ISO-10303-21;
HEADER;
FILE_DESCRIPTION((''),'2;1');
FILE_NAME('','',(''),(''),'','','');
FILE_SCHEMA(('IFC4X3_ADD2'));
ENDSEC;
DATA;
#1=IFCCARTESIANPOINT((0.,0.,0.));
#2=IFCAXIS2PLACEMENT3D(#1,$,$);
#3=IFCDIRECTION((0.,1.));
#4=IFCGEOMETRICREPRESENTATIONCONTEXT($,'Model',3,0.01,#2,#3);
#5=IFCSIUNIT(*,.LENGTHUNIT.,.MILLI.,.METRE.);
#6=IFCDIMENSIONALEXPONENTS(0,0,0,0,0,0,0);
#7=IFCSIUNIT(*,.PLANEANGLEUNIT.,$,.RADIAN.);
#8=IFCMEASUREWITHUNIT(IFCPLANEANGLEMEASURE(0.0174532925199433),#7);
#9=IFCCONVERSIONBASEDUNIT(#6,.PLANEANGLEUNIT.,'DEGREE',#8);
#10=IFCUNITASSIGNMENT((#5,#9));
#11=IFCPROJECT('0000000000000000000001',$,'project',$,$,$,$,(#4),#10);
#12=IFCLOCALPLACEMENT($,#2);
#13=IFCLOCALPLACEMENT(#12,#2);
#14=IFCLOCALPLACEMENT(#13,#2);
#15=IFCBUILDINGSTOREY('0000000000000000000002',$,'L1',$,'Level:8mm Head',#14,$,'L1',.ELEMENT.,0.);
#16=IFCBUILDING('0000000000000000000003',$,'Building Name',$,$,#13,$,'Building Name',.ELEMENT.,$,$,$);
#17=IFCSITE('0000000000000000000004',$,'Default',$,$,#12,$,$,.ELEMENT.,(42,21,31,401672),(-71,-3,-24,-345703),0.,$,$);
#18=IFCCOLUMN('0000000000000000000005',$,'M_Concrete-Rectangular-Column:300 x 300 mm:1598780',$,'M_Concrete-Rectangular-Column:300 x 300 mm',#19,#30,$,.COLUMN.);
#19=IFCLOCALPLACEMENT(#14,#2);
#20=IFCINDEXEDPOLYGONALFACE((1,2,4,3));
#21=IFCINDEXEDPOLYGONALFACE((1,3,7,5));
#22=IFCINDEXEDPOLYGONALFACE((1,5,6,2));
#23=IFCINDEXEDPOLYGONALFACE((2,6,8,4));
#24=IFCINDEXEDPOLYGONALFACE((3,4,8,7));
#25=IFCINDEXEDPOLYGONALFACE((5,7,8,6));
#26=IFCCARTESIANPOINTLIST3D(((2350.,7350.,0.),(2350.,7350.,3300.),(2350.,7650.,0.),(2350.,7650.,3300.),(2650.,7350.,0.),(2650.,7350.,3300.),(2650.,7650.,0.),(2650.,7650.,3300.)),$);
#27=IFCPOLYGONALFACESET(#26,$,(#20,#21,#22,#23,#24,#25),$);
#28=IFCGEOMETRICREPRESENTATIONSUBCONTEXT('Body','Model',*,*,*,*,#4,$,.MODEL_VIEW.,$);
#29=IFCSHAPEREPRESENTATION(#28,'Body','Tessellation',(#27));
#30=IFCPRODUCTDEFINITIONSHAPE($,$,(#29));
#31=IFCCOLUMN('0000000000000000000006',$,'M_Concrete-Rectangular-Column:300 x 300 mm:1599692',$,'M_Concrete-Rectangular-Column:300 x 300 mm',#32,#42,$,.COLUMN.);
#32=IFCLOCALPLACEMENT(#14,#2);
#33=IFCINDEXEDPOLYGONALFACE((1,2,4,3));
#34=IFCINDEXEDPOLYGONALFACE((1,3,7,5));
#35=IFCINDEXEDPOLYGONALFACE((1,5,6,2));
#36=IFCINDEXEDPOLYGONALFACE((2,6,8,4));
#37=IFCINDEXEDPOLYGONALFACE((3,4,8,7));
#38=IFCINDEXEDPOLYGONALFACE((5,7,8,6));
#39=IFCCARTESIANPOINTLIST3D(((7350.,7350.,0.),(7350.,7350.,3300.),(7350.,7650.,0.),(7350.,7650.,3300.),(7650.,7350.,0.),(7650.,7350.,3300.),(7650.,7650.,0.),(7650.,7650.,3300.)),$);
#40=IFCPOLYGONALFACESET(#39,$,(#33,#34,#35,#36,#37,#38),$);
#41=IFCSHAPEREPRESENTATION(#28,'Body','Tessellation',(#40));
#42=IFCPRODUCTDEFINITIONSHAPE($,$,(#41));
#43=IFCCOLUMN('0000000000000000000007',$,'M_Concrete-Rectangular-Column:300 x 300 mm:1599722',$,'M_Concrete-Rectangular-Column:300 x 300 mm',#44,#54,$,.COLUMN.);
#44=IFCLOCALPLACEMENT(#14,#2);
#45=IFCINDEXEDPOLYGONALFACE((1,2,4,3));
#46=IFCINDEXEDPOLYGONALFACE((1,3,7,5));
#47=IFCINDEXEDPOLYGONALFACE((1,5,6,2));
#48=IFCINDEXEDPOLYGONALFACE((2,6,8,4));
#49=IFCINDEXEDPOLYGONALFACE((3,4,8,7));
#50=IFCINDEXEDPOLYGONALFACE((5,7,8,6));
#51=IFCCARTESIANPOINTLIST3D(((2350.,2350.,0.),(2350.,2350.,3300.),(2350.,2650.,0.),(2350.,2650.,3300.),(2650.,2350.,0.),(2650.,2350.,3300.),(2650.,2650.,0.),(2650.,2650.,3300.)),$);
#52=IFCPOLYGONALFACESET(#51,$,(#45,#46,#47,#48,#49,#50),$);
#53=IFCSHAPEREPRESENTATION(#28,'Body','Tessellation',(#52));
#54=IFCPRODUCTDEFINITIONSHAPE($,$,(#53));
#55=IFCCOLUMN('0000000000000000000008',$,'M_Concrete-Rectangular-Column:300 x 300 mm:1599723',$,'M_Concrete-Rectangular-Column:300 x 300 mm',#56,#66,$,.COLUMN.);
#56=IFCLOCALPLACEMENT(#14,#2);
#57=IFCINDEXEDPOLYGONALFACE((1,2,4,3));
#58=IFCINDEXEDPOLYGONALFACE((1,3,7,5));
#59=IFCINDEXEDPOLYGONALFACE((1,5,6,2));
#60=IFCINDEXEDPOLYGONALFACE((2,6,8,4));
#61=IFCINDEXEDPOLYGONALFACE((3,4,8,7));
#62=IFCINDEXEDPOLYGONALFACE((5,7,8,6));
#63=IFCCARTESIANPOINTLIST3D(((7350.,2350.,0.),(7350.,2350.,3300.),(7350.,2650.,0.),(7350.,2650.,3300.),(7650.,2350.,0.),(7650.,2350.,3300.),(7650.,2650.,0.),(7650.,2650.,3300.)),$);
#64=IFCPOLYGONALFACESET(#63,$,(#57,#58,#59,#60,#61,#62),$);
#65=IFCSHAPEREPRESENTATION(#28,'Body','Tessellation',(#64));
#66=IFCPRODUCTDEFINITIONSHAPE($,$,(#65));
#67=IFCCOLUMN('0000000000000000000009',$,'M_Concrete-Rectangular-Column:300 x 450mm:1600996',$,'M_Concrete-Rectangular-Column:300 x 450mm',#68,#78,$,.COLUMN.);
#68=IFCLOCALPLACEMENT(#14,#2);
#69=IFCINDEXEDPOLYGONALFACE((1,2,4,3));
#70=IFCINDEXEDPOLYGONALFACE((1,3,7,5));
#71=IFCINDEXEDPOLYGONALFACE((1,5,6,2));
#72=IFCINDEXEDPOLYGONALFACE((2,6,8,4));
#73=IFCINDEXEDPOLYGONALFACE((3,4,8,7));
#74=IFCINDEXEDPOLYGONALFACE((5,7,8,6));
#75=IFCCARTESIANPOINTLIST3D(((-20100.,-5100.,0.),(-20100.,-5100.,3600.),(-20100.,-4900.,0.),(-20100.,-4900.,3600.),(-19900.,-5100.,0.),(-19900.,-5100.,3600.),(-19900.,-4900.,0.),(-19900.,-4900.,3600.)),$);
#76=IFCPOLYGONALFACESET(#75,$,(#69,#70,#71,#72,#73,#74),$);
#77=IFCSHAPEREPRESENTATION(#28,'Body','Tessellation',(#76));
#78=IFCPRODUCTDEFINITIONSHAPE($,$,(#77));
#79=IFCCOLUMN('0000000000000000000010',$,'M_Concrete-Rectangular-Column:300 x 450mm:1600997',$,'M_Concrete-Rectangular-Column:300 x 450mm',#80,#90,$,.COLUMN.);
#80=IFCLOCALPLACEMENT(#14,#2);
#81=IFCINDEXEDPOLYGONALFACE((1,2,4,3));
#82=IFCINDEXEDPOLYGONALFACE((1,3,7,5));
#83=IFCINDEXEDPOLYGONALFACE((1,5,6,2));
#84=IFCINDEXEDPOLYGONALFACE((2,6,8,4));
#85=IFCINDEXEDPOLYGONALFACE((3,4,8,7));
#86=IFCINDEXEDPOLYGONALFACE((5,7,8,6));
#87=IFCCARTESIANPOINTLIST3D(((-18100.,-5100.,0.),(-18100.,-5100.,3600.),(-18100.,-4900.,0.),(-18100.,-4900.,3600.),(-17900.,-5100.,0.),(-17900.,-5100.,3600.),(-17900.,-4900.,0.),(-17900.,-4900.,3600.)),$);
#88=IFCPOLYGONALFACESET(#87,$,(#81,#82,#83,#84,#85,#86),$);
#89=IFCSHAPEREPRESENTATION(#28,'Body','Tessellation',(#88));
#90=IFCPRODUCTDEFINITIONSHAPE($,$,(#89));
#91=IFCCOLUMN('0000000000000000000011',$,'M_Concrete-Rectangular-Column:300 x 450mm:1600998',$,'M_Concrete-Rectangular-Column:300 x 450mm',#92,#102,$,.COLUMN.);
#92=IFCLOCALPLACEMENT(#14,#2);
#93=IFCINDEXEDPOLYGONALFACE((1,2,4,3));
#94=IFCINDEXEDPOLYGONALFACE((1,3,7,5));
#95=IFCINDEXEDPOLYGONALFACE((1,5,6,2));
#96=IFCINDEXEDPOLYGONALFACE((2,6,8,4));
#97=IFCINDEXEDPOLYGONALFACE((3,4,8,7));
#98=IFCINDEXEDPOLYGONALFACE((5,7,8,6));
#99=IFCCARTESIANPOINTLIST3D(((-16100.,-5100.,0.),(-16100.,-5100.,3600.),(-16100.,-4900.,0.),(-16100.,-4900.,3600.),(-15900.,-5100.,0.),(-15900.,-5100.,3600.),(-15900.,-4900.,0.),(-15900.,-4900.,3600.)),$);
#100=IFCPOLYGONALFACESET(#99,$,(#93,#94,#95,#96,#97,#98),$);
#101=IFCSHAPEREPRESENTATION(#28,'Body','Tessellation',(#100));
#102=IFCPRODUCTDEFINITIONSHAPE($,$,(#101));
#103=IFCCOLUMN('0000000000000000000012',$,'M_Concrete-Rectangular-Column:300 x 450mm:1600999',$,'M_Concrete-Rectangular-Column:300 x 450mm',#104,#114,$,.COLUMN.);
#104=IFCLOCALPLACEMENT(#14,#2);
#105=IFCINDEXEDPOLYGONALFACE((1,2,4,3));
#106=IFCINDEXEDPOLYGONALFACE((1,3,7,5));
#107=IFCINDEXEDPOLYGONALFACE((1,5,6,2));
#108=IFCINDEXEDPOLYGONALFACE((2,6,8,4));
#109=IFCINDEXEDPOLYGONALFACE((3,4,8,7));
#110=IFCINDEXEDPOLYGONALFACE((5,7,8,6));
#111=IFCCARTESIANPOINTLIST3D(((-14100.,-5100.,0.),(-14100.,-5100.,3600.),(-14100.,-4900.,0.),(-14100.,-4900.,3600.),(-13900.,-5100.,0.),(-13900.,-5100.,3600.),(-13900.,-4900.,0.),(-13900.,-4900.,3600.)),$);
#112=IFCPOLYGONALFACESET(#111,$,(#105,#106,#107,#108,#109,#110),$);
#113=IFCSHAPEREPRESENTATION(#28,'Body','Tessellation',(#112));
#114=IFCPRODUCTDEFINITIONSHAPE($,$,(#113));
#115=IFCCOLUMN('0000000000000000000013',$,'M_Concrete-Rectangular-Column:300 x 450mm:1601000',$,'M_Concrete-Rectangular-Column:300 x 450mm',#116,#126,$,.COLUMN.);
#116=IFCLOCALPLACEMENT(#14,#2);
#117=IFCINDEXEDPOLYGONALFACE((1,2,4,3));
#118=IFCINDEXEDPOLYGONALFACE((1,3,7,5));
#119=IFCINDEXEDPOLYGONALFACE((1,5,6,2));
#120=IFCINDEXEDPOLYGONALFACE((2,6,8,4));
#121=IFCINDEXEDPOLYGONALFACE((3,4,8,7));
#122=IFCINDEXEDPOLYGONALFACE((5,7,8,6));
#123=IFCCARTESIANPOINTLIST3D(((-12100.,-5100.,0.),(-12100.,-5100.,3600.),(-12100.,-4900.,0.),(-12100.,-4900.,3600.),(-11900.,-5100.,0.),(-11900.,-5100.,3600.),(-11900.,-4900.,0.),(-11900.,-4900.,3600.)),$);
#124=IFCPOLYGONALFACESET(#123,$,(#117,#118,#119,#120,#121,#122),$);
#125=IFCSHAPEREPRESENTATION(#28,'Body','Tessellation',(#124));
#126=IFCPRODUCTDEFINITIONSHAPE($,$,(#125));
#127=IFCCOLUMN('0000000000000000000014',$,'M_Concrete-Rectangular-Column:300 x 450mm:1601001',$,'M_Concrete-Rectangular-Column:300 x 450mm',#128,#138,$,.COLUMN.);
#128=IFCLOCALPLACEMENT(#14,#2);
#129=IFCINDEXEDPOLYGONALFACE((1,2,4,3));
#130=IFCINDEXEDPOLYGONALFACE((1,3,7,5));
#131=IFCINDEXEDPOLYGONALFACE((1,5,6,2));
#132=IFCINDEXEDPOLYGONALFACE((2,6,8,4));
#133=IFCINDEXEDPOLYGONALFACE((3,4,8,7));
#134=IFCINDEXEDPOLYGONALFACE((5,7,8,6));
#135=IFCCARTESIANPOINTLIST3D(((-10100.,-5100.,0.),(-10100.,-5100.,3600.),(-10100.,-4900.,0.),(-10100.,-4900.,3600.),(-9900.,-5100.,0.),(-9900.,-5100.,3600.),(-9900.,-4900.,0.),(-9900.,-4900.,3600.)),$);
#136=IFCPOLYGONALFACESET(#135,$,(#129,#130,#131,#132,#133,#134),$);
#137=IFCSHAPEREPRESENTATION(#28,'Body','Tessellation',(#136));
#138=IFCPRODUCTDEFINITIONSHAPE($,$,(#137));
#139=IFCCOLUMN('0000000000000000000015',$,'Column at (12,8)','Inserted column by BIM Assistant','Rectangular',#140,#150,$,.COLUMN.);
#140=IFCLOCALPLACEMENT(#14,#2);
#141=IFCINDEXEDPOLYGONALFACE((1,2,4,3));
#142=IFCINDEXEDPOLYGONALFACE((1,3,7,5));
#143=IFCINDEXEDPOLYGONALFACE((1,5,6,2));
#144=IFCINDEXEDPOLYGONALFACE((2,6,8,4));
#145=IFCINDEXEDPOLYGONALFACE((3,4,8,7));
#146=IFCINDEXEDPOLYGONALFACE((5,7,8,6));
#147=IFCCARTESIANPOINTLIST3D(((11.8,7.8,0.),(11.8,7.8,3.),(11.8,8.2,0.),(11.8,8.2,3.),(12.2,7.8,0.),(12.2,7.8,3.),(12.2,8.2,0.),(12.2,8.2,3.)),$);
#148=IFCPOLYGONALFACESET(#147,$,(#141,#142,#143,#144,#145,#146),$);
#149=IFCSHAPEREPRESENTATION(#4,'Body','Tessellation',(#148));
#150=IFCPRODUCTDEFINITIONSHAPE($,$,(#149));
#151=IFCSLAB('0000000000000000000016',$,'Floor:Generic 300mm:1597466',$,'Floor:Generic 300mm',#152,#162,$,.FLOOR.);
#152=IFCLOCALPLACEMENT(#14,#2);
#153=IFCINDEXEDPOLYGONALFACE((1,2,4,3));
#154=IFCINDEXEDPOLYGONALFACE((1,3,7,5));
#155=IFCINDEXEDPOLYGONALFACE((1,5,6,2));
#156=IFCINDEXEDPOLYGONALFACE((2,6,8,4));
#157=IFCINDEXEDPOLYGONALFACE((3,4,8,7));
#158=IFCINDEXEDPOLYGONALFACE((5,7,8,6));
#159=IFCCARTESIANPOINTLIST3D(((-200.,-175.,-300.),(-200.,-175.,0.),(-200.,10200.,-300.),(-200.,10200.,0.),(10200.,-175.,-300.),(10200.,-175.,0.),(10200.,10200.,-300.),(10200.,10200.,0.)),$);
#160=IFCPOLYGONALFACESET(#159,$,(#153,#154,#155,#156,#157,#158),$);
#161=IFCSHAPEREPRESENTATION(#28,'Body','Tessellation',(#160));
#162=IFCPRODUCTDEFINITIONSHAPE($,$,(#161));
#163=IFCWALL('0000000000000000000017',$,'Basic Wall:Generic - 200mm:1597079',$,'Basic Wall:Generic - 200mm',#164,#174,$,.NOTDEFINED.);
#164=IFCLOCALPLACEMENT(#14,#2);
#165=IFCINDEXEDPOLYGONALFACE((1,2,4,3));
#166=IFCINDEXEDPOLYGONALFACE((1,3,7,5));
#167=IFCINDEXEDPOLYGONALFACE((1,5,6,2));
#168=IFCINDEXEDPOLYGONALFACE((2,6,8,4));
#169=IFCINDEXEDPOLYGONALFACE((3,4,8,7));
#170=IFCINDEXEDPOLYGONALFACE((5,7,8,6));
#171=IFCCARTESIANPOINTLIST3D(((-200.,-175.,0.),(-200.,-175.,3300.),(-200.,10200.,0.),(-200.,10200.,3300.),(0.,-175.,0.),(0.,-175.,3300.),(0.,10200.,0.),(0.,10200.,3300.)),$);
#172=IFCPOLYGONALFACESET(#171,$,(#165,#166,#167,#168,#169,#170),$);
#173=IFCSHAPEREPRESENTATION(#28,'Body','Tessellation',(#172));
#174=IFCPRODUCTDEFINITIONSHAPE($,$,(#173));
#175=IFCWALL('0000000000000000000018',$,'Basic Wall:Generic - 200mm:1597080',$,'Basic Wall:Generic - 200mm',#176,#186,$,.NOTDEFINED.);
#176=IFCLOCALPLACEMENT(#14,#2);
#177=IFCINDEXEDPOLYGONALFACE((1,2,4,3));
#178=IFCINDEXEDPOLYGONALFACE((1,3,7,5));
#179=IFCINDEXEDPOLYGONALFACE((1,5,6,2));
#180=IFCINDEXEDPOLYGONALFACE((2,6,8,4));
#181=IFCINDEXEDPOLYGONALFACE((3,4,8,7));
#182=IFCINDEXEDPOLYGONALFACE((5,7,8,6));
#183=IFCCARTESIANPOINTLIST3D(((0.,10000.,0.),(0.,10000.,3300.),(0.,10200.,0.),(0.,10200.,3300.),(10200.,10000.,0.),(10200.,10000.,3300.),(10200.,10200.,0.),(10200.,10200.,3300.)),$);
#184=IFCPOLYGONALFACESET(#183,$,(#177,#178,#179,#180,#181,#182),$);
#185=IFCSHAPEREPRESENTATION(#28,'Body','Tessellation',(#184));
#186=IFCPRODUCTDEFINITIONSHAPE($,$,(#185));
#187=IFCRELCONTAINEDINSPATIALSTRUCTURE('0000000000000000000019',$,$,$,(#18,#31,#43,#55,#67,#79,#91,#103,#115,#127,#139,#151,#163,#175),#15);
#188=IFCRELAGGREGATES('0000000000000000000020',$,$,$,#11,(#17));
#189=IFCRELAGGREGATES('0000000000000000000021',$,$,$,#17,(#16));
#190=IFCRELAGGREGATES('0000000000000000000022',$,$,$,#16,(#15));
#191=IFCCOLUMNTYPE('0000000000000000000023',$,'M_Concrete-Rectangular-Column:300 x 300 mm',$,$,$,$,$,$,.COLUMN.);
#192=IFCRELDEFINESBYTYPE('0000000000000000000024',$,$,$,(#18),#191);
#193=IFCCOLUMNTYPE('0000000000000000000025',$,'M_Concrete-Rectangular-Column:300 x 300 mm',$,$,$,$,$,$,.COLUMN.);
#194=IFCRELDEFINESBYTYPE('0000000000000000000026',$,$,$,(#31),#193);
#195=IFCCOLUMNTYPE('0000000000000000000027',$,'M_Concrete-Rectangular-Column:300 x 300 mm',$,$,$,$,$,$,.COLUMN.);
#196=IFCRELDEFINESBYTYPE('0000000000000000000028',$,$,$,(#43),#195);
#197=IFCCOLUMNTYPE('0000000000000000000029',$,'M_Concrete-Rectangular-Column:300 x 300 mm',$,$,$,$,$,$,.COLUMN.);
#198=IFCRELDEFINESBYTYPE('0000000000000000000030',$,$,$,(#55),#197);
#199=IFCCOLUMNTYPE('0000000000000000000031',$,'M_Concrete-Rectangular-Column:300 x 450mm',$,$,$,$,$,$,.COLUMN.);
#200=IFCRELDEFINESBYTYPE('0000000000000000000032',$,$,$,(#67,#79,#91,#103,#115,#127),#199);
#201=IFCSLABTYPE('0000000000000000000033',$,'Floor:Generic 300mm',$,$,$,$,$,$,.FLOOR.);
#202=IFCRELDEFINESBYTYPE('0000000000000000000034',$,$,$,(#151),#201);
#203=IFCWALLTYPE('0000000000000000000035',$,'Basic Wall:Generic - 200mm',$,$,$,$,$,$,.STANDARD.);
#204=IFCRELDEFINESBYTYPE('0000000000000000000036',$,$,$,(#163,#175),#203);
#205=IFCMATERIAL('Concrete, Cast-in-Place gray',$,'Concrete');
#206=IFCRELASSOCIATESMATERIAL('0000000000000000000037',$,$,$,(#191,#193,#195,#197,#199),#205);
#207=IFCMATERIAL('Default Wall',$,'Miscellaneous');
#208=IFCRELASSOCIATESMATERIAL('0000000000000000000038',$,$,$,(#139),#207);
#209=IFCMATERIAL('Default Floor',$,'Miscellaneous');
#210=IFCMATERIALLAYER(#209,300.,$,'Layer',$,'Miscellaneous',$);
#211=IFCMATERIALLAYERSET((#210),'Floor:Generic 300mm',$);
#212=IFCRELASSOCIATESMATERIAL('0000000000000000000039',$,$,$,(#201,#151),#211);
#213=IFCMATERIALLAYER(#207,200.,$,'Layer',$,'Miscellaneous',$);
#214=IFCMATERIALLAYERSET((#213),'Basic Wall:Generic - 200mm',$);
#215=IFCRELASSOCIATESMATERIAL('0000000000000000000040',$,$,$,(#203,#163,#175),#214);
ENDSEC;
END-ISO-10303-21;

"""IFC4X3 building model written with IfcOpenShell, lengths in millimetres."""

from ifc_helpers import new_model, entity, si_unit, converted_unit, direction, frame, frame_2d, origin, origin_2d, origin_2d_with_axis, place, context, subcontext, project, spatial, rectangle, extrude, source, transform, mapped, material, layer, layer_set, layer_usage, material_profile, profile_set, type_object, type_shapes, element, save


model = new_model("IFC4X3")

# Units and contexts
model_context = context("Model", 3, precision=0.01, world=origin(), true_north=direction((0.0, 1.0)))
body_context = subcontext(model_context, "Body", "Model", "MODEL_VIEW")
ifc_project = project(units=[si_unit("LENGTHUNIT", "METRE", prefix="MILLI"), converted_unit("PLANEANGLEUNIT", "DEGREE", entity("IfcPlaneAngleMeasure", 0.0174532925199433), si_unit("PLANEANGLEUNIT", "RADIAN"), dimensions=[0, 0, 0, 0, 0, 0, 0])], contexts=[model_context])

# Site, building, storey
site_placement = place(None, origin())
site = spatial("IfcSite", under=ifc_project, at=site_placement, Name="Default", CompositionType="ELEMENT", RefLatitude=(42, 21, 31, 401672), RefLongitude=(-71, -3, -24, -345703), RefElevation=0.0)
building_placement = place(site_placement, origin())
building = spatial("IfcBuilding", under=site, at=building_placement, Name="Building Name", LongName="Building Name", CompositionType="ELEMENT")
storey_placement = place(building_placement, origin())
storey = spatial("IfcBuildingStorey", under=building, at=storey_placement, Name="L1", ObjectType="Level:8mm Head", LongName="L1", CompositionType="ELEMENT", Elevation=0.0)

# Columns
ifc_material_1 = material(Name="Concrete, Cast-in-Place gray", Category="Concrete")
ifc_material_profile_1 = material_profile(ifc_material_1, rectangle(XDim=300.0, YDim=300.0, at=origin_2d_with_axis()), Name="300 x 300 mm")
ifc_profile_set_1 = profile_set([ifc_material_profile_1], Name="300 x 300 mm")
column_type_1 = type_object("IfcColumnType", Name="M_Concrete-Rectangular-Column:300 x 300 mm", PredefinedType="COLUMN", material=ifc_profile_set_1)
shared_shape_1 = source(origin(), body_context, "Body", "SweptSolid", [
    extrude(rectangle(XDim=300.0, YDim=300.0, at=origin_2d_with_axis()), frame((2500.0, 7500.0, 0.0)), (0.0, 0.0, 1.0), 3300.0),
])
type_shapes(column_type_1, [shared_shape_1])
column_1_placement = place(storey_placement, origin())
element("IfcColumn", 1, at=column_1_placement, inside=storey, type_object=column_type_1, Name="M_Concrete-Rectangular-Column:300 x 300 mm:1598780", ObjectType="M_Concrete-Rectangular-Column:300 x 300 mm", PredefinedType="COLUMN", context=body_context, shape_type="MappedRepresentation", body=[
    mapped(shared_shape_1, transform((0.0, 0.0, 0.0), scale=1.0)),
])
column_type_2 = type_object("IfcColumnType", Name="M_Concrete-Rectangular-Column:300 x 300 mm", PredefinedType="COLUMN", material=ifc_profile_set_1)
shared_shape_2 = source(origin(), body_context, "Body", "SweptSolid", [
    extrude(rectangle(XDim=300.0, YDim=300.0, at=origin_2d_with_axis()), frame((7500.0, 7500.0, 0.0)), (0.0, 0.0, 1.0), 3300.0),
])
type_shapes(column_type_2, [shared_shape_2])
column_2_placement = place(storey_placement, origin())
element("IfcColumn", 2, at=column_2_placement, inside=storey, type_object=column_type_2, Name="M_Concrete-Rectangular-Column:300 x 300 mm:1599692", ObjectType="M_Concrete-Rectangular-Column:300 x 300 mm", PredefinedType="COLUMN", context=body_context, shape_type="MappedRepresentation", body=[
    mapped(shared_shape_2, transform((0.0, 0.0, 0.0), scale=1.0)),
])
column_type_3 = type_object("IfcColumnType", Name="M_Concrete-Rectangular-Column:300 x 300 mm", PredefinedType="COLUMN", material=ifc_profile_set_1)
shared_shape_3 = source(origin(), body_context, "Body", "SweptSolid", [
    extrude(rectangle(XDim=300.0, YDim=300.0, at=origin_2d_with_axis()), frame((2500.0, 2500.0, 0.0)), (0.0, 0.0, 1.0), 3300.0),
])
type_shapes(column_type_3, [shared_shape_3])
column_3_placement = place(storey_placement, origin())
element("IfcColumn", 3, at=column_3_placement, inside=storey, type_object=column_type_3, Name="M_Concrete-Rectangular-Column:300 x 300 mm:1599722", ObjectType="M_Concrete-Rectangular-Column:300 x 300 mm", PredefinedType="COLUMN", context=body_context, shape_type="MappedRepresentation", body=[
    mapped(shared_shape_3, transform((0.0, 0.0, 0.0), scale=1.0)),
])
column_type_4 = type_object("IfcColumnType", Name="M_Concrete-Rectangular-Column:300 x 300 mm", PredefinedType="COLUMN", material=ifc_profile_set_1)
shared_shape_4 = source(origin(), body_context, "Body", "SweptSolid", [
    extrude(rectangle(XDim=300.0, YDim=300.0, at=origin_2d_with_axis()), frame((7500.0, 2500.0, 0.0)), (0.0, 0.0, 1.0), 3300.0),
])
type_shapes(column_type_4, [shared_shape_4])
column_4_placement = place(storey_placement, origin())
element("IfcColumn", 4, at=column_4_placement, inside=storey, type_object=column_type_4, Name="M_Concrete-Rectangular-Column:300 x 300 mm:1599723", ObjectType="M_Concrete-Rectangular-Column:300 x 300 mm", PredefinedType="COLUMN", context=body_context, shape_type="MappedRepresentation", body=[
    mapped(shared_shape_4, transform((0.0, 0.0, 0.0), scale=1.0)),
])
ifc_material_profile_2 = material_profile(ifc_material_1, rectangle(XDim=200.0, YDim=200.0, at=origin_2d_with_axis()), Name="300 x 450mm")
ifc_profile_set_2 = profile_set([ifc_material_profile_2], Name="300 x 450mm")
column_type_5 = type_object("IfcColumnType", Name="M_Concrete-Rectangular-Column:300 x 450mm", PredefinedType="COLUMN", material=ifc_profile_set_2)
shared_shape_5 = source(origin(), body_context, "Body", "SweptSolid", [
    extrude(rectangle(XDim=200.0, YDim=200.0, at=origin_2d_with_axis()), frame((0.0, 0.0, 0.0), z_axis=(0.0, 0.0, 1.0), x_axis=(-1.0, 0.0, 0.0)), (0.0, 0.0, 1.0), 3600.0),
])
type_shapes(column_type_5, [shared_shape_5])
for number, where, z_axis, x_axis, name in (
    (5, (-20000.0, -5000.0, 0.0), (0.0, 0.0, 1.0), (0.0, -1.0, 0.0), "M_Concrete-Rectangular-Column:300 x 450mm:1600996"),
    (6, (-18000.0, -5000.0, 0.0), (0.0, 0.0, 1.0), (0.0, -1.0, 0.0), "M_Concrete-Rectangular-Column:300 x 450mm:1600997"),
    (7, (-16000.0, -5000.0, 0.0), (0.0, 0.0, 1.0), (0.0, -1.0, 0.0), "M_Concrete-Rectangular-Column:300 x 450mm:1600998"),
    (8, (-14000.0, -5000.0, 0.0), (0.0, 0.0, 1.0), (0.0, -1.0, 0.0), "M_Concrete-Rectangular-Column:300 x 450mm:1600999"),
    (9, (-12000.0, -5000.0, 0.0), (0.0, 0.0, 1.0), (0.0, -1.0, 0.0), "M_Concrete-Rectangular-Column:300 x 450mm:1601000"),
    (10, (-10000.0, -5000.0, 0.0), (0.0, 0.0, 1.0), (0.0, -1.0, 0.0), "M_Concrete-Rectangular-Column:300 x 450mm:1601001"),
):
    element("IfcColumn", number, at=place(storey_placement, frame(where, z_axis=z_axis, x_axis=x_axis)), inside=storey, type_object=column_type_5, Name=name, ObjectType="M_Concrete-Rectangular-Column:300 x 450mm", PredefinedType="COLUMN", context=body_context, shape_type="MappedRepresentation", body=[
        mapped(shared_shape_5, transform((0.0, 0.0, 0.0), scale=1.0)),
    ])
ifc_material_2 = material(Name="Default Wall", Category="Miscellaneous")
column_5_placement = place(storey_placement, frame((12.0, 8.0, 0.0)))
element("IfcColumn", 11, at=column_5_placement, inside=storey, material=ifc_material_2, Name="Column at (12,8)", Description="Inserted column by BIM Assistant", ObjectType="Rectangular", PredefinedType="COLUMN", context=model_context, shape_type="SweptSolid", body=[
    extrude(rectangle(XDim=0.4, YDim=0.4, at=origin_2d()), origin(), (0.0, 0.0, 1.0), 3.0),
])

# Slab
ifc_material_3 = material(Name="Default Floor", Category="Miscellaneous")
ifc_layer_1 = layer(ifc_material_3, 300.0, Name="Layer", Category="Miscellaneous")
ifc_layer_set_1 = layer_set([ifc_layer_1], Name="Floor:Generic 300mm")
ifc_layer_usage = layer_usage(ifc_layer_set_1, "AXIS3", "POSITIVE", 0.0)
slab_type = type_object("IfcSlabType", Name="Floor:Generic 300mm", PredefinedType="FLOOR", material=ifc_layer_set_1)
slab_placement = place(storey_placement, origin())
element("IfcSlab", 12, at=slab_placement, inside=storey, type_object=slab_type, material=ifc_layer_usage, Name="Floor:Generic 300mm:1597466", ObjectType="Floor:Generic 300mm", PredefinedType="FLOOR", context=body_context, shape_type="SweptSolid", body=[
    extrude(rectangle(XDim=10375.0, YDim=10400.0, at=origin_2d_with_axis()), frame((5000.0, 5012.5, 0.0), z_axis=(0.0, 0.0, -1.0), x_axis=(0.0, 1.0, 0.0)), (0.0, 0.0, 1.0), 300.0),
])

# Walls
ifc_layer_2 = layer(ifc_material_2, 200.0, Name="Layer", Category="Miscellaneous")
ifc_layer_set_2 = layer_set([ifc_layer_2], Name="Basic Wall:Generic - 200mm")
wall_type_1 = type_object("IfcWallType", Name="Basic Wall:Generic - 200mm", PredefinedType="STANDARD", material=ifc_layer_set_2)
wall_1_placement = place(storey_placement, frame((-100.0, 10200.0, 0.0), z_axis=(0.0, 0.0, 1.0), x_axis=(0.0, -1.0, 0.0)))
element("IfcWall", 13, at=wall_1_placement, inside=storey, type_object=wall_type_1, material=ifc_layer_set_2, Name="Basic Wall:Generic - 200mm:1597079", ObjectType="Basic Wall:Generic - 200mm", PredefinedType="NOTDEFINED", context=body_context, shape_type="SweptSolid", body=[
    extrude(rectangle(XDim=10375.0, YDim=200.0, at=frame_2d((5187.5, 0.0), x_axis=(-1.0, 0.0))), origin(), (0.0, 0.0, 1.0), 3300.0),
])
wall_2_placement = place(storey_placement, frame((10200.0, 10100.0, 0.0), z_axis=(0.0, 0.0, 1.0), x_axis=(-1.0, 0.0, 0.0)))
element("IfcWall", 14, at=wall_2_placement, inside=storey, type_object=wall_type_1, material=ifc_layer_set_2, Name="Basic Wall:Generic - 200mm:1597080", ObjectType="Basic Wall:Generic - 200mm", PredefinedType="NOTDEFINED", context=body_context, shape_type="SweptSolid", body=[
    extrude(rectangle(XDim=10200.0, YDim=200.0, at=frame_2d((5100.0, 0.0), x_axis=(-1.0, 0.0))), origin(), (0.0, 0.0, 1.0), 3300.0),
])

save(model, "model.ifc")
